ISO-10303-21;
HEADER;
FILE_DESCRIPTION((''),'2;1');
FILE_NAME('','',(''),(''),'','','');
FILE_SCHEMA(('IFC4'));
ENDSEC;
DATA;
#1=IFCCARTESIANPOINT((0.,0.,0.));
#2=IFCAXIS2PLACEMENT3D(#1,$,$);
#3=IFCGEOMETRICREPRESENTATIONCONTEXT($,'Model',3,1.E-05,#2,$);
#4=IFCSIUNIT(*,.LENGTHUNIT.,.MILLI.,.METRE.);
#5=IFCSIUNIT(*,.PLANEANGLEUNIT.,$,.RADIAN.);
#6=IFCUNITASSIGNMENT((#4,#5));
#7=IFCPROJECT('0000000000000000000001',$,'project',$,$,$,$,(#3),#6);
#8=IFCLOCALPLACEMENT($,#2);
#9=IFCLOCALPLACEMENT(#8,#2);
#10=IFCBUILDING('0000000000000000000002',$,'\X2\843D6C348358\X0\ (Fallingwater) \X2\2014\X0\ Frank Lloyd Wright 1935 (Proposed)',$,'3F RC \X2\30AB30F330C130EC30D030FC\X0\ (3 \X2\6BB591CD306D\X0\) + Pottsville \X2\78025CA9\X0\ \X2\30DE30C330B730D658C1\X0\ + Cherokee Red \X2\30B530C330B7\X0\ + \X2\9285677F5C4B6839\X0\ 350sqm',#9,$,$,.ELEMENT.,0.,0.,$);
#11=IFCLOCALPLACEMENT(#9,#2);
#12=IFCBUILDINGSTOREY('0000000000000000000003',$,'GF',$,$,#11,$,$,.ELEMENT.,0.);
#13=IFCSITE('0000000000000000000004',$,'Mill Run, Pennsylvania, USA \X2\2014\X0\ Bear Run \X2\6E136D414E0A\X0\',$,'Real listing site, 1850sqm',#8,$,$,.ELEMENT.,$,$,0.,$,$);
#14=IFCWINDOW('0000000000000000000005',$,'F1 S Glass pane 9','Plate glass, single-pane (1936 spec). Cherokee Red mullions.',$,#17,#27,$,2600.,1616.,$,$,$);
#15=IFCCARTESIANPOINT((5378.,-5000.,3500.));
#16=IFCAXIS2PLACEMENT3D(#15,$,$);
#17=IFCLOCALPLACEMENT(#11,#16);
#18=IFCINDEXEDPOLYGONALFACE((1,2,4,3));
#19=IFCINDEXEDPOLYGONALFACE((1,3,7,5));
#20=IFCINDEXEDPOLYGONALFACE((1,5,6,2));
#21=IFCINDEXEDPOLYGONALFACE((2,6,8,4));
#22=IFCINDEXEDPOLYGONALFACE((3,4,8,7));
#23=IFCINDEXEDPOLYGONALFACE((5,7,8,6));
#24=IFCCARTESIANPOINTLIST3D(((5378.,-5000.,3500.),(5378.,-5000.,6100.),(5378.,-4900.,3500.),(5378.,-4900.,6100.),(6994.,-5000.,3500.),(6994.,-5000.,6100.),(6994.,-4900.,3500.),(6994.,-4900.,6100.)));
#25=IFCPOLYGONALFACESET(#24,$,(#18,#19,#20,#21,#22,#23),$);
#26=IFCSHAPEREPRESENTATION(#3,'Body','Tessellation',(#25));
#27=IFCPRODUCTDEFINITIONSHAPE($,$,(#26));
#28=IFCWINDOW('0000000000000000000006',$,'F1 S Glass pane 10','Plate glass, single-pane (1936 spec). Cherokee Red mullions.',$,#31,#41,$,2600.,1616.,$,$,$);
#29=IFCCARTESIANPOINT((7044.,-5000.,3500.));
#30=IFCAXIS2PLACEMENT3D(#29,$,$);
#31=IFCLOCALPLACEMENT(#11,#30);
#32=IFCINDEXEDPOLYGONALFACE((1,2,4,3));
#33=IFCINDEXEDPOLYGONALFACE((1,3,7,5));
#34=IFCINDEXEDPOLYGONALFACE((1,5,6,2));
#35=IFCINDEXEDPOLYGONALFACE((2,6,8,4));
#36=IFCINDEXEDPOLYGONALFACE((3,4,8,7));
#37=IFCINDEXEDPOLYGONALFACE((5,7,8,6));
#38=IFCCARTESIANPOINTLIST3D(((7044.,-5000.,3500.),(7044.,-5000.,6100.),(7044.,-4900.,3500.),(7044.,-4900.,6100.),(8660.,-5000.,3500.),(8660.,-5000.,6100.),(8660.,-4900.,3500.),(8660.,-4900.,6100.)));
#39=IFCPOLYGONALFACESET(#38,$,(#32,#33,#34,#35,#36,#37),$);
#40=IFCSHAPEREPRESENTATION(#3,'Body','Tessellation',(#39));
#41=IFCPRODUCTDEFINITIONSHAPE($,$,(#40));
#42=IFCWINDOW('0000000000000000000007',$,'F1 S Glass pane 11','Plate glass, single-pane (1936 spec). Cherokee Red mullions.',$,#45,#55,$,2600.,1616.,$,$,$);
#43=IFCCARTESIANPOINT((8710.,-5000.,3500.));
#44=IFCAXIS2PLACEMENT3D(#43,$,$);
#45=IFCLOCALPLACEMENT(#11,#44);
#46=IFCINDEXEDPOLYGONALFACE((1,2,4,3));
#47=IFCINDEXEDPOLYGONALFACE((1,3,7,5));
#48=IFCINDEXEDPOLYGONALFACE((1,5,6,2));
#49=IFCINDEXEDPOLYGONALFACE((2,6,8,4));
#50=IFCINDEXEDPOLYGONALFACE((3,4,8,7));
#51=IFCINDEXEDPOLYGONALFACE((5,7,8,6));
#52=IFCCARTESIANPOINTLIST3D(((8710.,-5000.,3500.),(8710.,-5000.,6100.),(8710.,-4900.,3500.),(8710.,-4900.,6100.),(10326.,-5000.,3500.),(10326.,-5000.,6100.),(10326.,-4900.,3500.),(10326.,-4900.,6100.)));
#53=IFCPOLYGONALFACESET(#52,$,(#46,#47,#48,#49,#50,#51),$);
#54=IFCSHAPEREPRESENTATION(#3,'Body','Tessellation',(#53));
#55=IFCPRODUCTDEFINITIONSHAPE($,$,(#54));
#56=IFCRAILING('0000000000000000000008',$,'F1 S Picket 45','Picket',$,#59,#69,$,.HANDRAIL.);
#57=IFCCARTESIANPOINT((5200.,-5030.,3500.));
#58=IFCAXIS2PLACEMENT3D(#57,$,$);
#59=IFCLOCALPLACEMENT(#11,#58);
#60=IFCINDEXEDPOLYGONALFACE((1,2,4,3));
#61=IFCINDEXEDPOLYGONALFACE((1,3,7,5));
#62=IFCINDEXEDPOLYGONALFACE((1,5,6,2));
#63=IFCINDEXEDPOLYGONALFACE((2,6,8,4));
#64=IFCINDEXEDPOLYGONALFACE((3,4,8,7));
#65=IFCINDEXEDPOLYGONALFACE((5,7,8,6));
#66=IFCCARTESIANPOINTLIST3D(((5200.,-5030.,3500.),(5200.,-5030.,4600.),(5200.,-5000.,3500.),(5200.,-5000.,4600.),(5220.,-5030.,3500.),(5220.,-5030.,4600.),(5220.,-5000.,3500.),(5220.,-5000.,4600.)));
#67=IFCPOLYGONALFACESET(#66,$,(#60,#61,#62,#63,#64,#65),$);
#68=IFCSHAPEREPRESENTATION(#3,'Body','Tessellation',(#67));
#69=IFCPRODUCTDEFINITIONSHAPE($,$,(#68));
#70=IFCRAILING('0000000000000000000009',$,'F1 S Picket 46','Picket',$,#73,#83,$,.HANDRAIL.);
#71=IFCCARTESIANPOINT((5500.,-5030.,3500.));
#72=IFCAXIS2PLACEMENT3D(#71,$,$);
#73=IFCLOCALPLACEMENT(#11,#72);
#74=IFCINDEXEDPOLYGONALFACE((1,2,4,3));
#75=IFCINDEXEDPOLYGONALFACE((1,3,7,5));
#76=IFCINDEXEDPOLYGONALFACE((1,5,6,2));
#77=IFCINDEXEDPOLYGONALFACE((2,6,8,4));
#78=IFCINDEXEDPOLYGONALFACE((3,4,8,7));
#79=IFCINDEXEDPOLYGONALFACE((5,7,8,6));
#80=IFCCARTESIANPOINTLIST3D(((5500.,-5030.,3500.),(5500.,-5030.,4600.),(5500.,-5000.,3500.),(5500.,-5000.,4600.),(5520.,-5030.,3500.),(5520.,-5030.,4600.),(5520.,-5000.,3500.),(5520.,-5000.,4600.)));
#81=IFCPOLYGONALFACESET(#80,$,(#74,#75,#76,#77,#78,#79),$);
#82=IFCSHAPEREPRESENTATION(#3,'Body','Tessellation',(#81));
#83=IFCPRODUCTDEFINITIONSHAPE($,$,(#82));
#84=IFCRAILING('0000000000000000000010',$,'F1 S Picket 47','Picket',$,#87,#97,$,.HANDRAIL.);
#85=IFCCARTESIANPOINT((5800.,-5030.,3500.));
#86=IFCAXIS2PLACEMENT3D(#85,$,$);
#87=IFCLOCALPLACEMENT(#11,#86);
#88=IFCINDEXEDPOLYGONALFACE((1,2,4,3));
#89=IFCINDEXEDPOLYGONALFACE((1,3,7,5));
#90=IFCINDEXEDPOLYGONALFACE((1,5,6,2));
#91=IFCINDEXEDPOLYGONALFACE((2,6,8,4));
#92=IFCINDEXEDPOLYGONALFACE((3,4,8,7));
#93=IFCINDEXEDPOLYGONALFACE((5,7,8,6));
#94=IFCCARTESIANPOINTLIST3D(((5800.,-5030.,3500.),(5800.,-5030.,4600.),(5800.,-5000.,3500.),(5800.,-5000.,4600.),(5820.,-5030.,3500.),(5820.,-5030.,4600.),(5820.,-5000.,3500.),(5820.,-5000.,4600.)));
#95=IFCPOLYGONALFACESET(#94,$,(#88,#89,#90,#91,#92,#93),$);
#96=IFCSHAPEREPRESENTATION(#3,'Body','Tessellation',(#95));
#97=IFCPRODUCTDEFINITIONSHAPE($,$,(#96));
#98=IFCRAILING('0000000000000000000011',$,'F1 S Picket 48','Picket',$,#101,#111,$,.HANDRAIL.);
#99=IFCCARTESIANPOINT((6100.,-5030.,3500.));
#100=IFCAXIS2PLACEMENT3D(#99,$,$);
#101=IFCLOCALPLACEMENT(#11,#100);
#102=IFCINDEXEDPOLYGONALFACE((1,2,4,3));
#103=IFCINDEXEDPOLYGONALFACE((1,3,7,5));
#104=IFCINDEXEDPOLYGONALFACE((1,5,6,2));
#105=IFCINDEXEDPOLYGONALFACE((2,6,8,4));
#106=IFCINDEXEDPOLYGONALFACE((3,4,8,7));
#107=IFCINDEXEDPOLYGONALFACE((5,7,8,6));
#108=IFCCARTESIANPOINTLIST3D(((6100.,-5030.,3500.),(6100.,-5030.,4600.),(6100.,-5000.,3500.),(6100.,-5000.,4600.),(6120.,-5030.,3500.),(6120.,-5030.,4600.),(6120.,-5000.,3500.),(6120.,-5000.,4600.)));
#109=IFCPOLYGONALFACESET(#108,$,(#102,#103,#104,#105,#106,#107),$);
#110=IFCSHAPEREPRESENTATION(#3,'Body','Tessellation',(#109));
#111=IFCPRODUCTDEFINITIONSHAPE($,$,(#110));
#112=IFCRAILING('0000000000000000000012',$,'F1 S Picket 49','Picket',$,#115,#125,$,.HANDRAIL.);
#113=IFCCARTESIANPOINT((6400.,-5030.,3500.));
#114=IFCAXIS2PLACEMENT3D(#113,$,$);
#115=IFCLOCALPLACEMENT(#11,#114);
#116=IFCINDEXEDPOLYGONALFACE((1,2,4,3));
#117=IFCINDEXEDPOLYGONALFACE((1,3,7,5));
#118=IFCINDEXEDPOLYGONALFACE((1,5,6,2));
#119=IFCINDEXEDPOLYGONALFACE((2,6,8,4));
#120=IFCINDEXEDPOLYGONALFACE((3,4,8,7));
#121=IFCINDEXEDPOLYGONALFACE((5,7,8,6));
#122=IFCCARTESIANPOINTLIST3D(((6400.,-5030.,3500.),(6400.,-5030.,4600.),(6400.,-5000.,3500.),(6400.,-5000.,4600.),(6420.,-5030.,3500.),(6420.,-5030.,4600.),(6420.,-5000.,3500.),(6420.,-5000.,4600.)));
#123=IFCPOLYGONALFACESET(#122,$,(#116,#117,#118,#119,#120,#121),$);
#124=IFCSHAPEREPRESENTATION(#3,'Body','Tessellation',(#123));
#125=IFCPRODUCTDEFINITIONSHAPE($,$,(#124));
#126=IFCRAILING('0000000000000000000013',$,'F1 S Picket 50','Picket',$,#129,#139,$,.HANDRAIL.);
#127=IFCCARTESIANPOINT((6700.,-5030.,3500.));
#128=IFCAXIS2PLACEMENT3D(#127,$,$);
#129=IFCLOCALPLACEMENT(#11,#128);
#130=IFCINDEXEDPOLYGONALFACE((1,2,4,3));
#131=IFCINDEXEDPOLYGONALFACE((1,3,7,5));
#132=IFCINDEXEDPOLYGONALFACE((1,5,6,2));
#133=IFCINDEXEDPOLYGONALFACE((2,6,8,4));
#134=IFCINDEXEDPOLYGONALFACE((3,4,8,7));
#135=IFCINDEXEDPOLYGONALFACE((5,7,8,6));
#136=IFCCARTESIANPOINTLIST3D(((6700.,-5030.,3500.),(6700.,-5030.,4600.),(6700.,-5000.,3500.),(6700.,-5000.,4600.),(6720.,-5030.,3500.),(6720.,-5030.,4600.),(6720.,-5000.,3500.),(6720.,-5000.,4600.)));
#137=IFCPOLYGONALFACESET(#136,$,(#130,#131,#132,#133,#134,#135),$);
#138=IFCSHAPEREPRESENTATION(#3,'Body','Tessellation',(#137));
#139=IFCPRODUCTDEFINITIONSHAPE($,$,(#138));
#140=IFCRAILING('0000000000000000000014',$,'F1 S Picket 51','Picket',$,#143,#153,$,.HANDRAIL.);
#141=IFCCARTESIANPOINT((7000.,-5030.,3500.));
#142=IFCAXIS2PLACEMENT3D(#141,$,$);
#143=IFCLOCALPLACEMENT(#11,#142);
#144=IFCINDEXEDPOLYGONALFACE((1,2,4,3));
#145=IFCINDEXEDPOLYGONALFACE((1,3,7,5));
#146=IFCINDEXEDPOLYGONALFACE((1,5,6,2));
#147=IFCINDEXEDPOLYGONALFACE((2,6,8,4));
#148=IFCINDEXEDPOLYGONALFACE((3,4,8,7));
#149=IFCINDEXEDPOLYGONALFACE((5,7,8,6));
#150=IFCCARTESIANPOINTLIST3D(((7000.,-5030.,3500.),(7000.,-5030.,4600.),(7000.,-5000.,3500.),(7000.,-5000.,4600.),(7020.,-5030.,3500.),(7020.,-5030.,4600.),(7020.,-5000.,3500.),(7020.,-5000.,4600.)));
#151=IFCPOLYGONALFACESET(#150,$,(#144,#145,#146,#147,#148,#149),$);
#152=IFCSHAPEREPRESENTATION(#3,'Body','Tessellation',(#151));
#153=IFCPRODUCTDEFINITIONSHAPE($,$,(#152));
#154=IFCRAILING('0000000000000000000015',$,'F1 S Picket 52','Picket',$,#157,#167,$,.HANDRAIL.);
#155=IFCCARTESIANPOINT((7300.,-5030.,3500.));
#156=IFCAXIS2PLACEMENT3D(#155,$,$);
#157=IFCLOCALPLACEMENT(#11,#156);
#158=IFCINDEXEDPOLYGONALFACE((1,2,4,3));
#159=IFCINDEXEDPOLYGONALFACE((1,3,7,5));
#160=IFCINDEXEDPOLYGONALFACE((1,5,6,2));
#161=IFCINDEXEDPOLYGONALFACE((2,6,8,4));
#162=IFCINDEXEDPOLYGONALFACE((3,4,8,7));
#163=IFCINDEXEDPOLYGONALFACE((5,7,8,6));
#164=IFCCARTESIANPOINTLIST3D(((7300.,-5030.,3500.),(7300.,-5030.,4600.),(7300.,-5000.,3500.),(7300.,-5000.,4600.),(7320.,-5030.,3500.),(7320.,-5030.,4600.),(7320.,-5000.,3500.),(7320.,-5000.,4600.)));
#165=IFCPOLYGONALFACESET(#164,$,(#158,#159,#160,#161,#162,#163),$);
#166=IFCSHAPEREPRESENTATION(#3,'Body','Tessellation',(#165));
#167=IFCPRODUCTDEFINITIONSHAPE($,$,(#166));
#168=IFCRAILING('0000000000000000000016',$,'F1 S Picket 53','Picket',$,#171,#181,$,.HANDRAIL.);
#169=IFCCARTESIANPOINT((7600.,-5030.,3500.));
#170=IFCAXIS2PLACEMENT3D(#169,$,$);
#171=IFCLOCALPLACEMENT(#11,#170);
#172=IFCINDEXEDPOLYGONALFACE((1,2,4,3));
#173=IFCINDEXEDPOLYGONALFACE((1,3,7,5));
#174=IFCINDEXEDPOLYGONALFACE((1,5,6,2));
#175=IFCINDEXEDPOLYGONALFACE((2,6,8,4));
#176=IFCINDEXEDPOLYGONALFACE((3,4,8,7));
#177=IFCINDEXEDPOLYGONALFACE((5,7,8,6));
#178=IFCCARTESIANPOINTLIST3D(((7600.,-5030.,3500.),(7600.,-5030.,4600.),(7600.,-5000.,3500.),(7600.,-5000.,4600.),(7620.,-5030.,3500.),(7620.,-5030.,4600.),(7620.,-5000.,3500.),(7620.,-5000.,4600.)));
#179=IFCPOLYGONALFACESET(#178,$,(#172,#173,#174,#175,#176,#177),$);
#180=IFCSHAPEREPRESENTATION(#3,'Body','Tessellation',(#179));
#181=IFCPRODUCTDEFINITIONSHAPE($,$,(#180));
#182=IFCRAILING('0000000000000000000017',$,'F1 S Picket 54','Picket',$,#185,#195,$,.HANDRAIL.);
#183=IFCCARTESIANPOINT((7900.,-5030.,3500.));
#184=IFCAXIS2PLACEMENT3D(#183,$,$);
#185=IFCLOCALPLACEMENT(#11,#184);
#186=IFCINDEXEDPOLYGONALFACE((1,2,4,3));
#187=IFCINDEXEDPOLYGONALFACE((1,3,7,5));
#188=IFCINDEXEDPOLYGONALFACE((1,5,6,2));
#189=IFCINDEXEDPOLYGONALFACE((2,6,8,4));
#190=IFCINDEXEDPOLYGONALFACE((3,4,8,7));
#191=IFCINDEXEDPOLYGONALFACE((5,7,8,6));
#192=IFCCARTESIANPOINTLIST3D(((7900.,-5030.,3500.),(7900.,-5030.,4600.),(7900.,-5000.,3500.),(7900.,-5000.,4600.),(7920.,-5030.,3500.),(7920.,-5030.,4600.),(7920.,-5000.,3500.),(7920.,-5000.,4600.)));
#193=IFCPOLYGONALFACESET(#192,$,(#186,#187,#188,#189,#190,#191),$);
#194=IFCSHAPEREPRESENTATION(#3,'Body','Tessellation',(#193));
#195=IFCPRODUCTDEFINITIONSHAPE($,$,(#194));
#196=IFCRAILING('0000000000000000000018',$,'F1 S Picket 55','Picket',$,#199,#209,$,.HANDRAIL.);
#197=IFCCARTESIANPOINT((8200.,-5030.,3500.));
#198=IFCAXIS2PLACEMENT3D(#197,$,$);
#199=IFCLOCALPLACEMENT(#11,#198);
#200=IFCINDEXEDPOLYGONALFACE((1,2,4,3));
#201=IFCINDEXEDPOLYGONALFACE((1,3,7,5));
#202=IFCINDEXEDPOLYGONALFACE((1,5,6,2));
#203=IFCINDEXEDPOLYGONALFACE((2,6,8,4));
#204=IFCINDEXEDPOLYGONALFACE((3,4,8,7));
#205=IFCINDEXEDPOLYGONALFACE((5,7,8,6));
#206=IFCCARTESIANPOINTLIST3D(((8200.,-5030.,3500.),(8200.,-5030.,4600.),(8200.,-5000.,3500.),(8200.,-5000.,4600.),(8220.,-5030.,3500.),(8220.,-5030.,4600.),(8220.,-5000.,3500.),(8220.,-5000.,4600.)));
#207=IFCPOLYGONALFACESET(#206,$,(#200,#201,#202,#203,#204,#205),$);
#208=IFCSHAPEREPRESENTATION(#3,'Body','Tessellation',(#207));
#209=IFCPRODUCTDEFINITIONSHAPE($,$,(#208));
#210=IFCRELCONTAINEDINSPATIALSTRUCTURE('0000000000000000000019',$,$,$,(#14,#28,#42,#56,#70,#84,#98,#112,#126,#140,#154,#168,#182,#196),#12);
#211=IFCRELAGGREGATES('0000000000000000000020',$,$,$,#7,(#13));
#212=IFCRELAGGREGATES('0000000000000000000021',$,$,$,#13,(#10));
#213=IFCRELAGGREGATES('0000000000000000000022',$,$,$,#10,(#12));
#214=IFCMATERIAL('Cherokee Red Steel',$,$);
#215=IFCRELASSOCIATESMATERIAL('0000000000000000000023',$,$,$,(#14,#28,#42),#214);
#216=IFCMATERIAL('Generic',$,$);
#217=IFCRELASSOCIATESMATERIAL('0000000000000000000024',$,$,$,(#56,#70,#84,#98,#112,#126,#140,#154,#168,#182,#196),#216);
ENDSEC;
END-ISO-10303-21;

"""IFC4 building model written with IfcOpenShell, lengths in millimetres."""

from ifc_helpers import new_model, si_unit, frame, frame_2d, origin, place, context, project, spatial, rectangle, extrude, material, element, save


model = new_model("IFC4")

# Units and contexts
model_context = context("Model", 3, precision=1e-05, world=origin())
ifc_project = project(units=[si_unit("LENGTHUNIT", "METRE", prefix="MILLI"), si_unit("PLANEANGLEUNIT", "RADIAN")], contexts=[model_context])

# Site, building, storey
site_placement = place(None, origin())
site = spatial("IfcSite", under=ifc_project, at=site_placement, Name="Mill Run, Pennsylvania, USA — Bear Run 渓流上", ObjectType="Real listing site, 1850sqm", CompositionType="ELEMENT", RefElevation=0.0)
building_placement = place(site_placement, origin())
building = spatial("IfcBuilding", under=site, at=building_placement, Name="落水荘 (Fallingwater) — Frank Lloyd Wright 1935 (Proposed)", ObjectType="3F RC カンチレバー (3 段重ね) + Pottsville 砂岩 マッシブ壁 + Cherokee Red サッシ + 銅板屋根 350sqm", CompositionType="ELEMENT", ElevationOfRefHeight=0.0, ElevationOfTerrain=0.0)
storey_placement = place(building_placement, origin())
storey = spatial("IfcBuildingStorey", under=building, at=storey_placement, Name="GF", CompositionType="ELEMENT", Elevation=0.0)

# Windows
ifc_material_1 = material(Name="Cherokee Red Steel")
window_1_placement = place(storey_placement, frame((5378.0, -5000.0, 3500.0)))
element("IfcWindow", 1, at=window_1_placement, inside=storey, material=ifc_material_1, Name="F1 S Glass pane 9", Description="Plate glass, single-pane (1936 spec). Cherokee Red mullions.", OverallHeight=2600.0, OverallWidth=1616.0, context=model_context, shape_type="SweptSolid", body=[
    extrude(rectangle(XDim=1616.0, YDim=100.0, at=frame_2d((808.0, 50.0))), frame((5378.0, -5000.0, 3500.0)), (0.0, 0.0, 1.0), 2600.0),
])
window_2_placement = place(storey_placement, frame((7044.0, -5000.0, 3500.0)))
element("IfcWindow", 2, at=window_2_placement, inside=storey, material=ifc_material_1, Name="F1 S Glass pane 10", Description="Plate glass, single-pane (1936 spec). Cherokee Red mullions.", OverallHeight=2600.0, OverallWidth=1616.0, context=model_context, shape_type="SweptSolid", body=[
    extrude(rectangle(XDim=1616.0, YDim=100.0, at=frame_2d((808.0, 50.0))), frame((7044.0, -5000.0, 3500.0)), (0.0, 0.0, 1.0), 2600.0),
])
window_3_placement = place(storey_placement, frame((8710.0, -5000.0, 3500.0)))
element("IfcWindow", 3, at=window_3_placement, inside=storey, material=ifc_material_1, Name="F1 S Glass pane 11", Description="Plate glass, single-pane (1936 spec). Cherokee Red mullions.", OverallHeight=2600.0, OverallWidth=1616.0, context=model_context, shape_type="SweptSolid", body=[
    extrude(rectangle(XDim=1616.0, YDim=100.0, at=frame_2d((808.0, 50.0))), frame((8710.0, -5000.0, 3500.0)), (0.0, 0.0, 1.0), 2600.0),
])

# Railings
ifc_material_2 = material(Name="Generic")
railing_1_placement = place(storey_placement, frame((5200.0, -5030.0, 3500.0)))
element("IfcRailing", 4, at=railing_1_placement, inside=storey, material=ifc_material_2, Name="F1 S Picket 45", Description="Picket", PredefinedType="HANDRAIL", context=model_context, shape_type="SweptSolid", body=[
    extrude(rectangle(XDim=20.0, YDim=30.0, at=frame_2d((10.0, 15.0))), frame((5200.0, -5030.0, 3500.0)), (0.0, 0.0, 1.0), 1100.0),
])
railing_2_placement = place(storey_placement, frame((5500.0, -5030.0, 3500.0)))
element("IfcRailing", 5, at=railing_2_placement, inside=storey, material=ifc_material_2, Name="F1 S Picket 46", Description="Picket", PredefinedType="HANDRAIL", context=model_context, shape_type="SweptSolid", body=[
    extrude(rectangle(XDim=20.0, YDim=30.0, at=frame_2d((10.0, 15.0))), frame((5500.0, -5030.0, 3500.0)), (0.0, 0.0, 1.0), 1100.0),
])
railing_3_placement = place(storey_placement, frame((5800.0, -5030.0, 3500.0)))
element("IfcRailing", 6, at=railing_3_placement, inside=storey, material=ifc_material_2, Name="F1 S Picket 47", Description="Picket", PredefinedType="HANDRAIL", context=model_context, shape_type="SweptSolid", body=[
    extrude(rectangle(XDim=20.0, YDim=30.0, at=frame_2d((10.0, 15.0))), frame((5800.0, -5030.0, 3500.0)), (0.0, 0.0, 1.0), 1100.0),
])
railing_4_placement = place(storey_placement, frame((6100.0, -5030.0, 3500.0)))
element("IfcRailing", 7, at=railing_4_placement, inside=storey, material=ifc_material_2, Name="F1 S Picket 48", Description="Picket", PredefinedType="HANDRAIL", context=model_context, shape_type="SweptSolid", body=[
    extrude(rectangle(XDim=20.0, YDim=30.0, at=frame_2d((10.0, 15.0))), frame((6100.0, -5030.0, 3500.0)), (0.0, 0.0, 1.0), 1100.0),
])
railing_5_placement = place(storey_placement, frame((6400.0, -5030.0, 3500.0)))
element("IfcRailing", 8, at=railing_5_placement, inside=storey, material=ifc_material_2, Name="F1 S Picket 49", Description="Picket", PredefinedType="HANDRAIL", context=model_context, shape_type="SweptSolid", body=[
    extrude(rectangle(XDim=20.0, YDim=30.0, at=frame_2d((10.0, 15.0))), frame((6400.0, -5030.0, 3500.0)), (0.0, 0.0, 1.0), 1100.0),
])
railing_6_placement = place(storey_placement, frame((6700.0, -5030.0, 3500.0)))
element("IfcRailing", 9, at=railing_6_placement, inside=storey, material=ifc_material_2, Name="F1 S Picket 50", Description="Picket", PredefinedType="HANDRAIL", context=model_context, shape_type="SweptSolid", body=[
    extrude(rectangle(XDim=20.0, YDim=30.0, at=frame_2d((10.0, 15.0))), frame((6700.0, -5030.0, 3500.0)), (0.0, 0.0, 1.0), 1100.0),
])
railing_7_placement = place(storey_placement, frame((7000.0, -5030.0, 3500.0)))
element("IfcRailing", 10, at=railing_7_placement, inside=storey, material=ifc_material_2, Name="F1 S Picket 51", Description="Picket", PredefinedType="HANDRAIL", context=model_context, shape_type="SweptSolid", body=[
    extrude(rectangle(XDim=20.0, YDim=30.0, at=frame_2d((10.0, 15.0))), frame((7000.0, -5030.0, 3500.0)), (0.0, 0.0, 1.0), 1100.0),
])
railing_8_placement = place(storey_placement, frame((7300.0, -5030.0, 3500.0)))
element("IfcRailing", 11, at=railing_8_placement, inside=storey, material=ifc_material_2, Name="F1 S Picket 52", Description="Picket", PredefinedType="HANDRAIL", context=model_context, shape_type="SweptSolid", body=[
    extrude(rectangle(XDim=20.0, YDim=30.0, at=frame_2d((10.0, 15.0))), frame((7300.0, -5030.0, 3500.0)), (0.0, 0.0, 1.0), 1100.0),
])
railing_9_placement = place(storey_placement, frame((7600.0, -5030.0, 3500.0)))
element("IfcRailing", 12, at=railing_9_placement, inside=storey, material=ifc_material_2, Name="F1 S Picket 53", Description="Picket", PredefinedType="HANDRAIL", context=model_context, shape_type="SweptSolid", body=[
    extrude(rectangle(XDim=20.0, YDim=30.0, at=frame_2d((10.0, 15.0))), frame((7600.0, -5030.0, 3500.0)), (0.0, 0.0, 1.0), 1100.0),
])
railing_10_placement = place(storey_placement, frame((7900.0, -5030.0, 3500.0)))
element("IfcRailing", 13, at=railing_10_placement, inside=storey, material=ifc_material_2, Name="F1 S Picket 54", Description="Picket", PredefinedType="HANDRAIL", context=model_context, shape_type="SweptSolid", body=[
    extrude(rectangle(XDim=20.0, YDim=30.0, at=frame_2d((10.0, 15.0))), frame((7900.0, -5030.0, 3500.0)), (0.0, 0.0, 1.0), 1100.0),
])
railing_11_placement = place(storey_placement, frame((8200.0, -5030.0, 3500.0)))
element("IfcRailing", 14, at=railing_11_placement, inside=storey, material=ifc_material_2, Name="F1 S Picket 55", Description="Picket", PredefinedType="HANDRAIL", context=model_context, shape_type="SweptSolid", body=[
    extrude(rectangle(XDim=20.0, YDim=30.0, at=frame_2d((10.0, 15.0))), frame((8200.0, -5030.0, 3500.0)), (0.0, 0.0, 1.0), 1100.0),
])

save(model, "model.ifc")
